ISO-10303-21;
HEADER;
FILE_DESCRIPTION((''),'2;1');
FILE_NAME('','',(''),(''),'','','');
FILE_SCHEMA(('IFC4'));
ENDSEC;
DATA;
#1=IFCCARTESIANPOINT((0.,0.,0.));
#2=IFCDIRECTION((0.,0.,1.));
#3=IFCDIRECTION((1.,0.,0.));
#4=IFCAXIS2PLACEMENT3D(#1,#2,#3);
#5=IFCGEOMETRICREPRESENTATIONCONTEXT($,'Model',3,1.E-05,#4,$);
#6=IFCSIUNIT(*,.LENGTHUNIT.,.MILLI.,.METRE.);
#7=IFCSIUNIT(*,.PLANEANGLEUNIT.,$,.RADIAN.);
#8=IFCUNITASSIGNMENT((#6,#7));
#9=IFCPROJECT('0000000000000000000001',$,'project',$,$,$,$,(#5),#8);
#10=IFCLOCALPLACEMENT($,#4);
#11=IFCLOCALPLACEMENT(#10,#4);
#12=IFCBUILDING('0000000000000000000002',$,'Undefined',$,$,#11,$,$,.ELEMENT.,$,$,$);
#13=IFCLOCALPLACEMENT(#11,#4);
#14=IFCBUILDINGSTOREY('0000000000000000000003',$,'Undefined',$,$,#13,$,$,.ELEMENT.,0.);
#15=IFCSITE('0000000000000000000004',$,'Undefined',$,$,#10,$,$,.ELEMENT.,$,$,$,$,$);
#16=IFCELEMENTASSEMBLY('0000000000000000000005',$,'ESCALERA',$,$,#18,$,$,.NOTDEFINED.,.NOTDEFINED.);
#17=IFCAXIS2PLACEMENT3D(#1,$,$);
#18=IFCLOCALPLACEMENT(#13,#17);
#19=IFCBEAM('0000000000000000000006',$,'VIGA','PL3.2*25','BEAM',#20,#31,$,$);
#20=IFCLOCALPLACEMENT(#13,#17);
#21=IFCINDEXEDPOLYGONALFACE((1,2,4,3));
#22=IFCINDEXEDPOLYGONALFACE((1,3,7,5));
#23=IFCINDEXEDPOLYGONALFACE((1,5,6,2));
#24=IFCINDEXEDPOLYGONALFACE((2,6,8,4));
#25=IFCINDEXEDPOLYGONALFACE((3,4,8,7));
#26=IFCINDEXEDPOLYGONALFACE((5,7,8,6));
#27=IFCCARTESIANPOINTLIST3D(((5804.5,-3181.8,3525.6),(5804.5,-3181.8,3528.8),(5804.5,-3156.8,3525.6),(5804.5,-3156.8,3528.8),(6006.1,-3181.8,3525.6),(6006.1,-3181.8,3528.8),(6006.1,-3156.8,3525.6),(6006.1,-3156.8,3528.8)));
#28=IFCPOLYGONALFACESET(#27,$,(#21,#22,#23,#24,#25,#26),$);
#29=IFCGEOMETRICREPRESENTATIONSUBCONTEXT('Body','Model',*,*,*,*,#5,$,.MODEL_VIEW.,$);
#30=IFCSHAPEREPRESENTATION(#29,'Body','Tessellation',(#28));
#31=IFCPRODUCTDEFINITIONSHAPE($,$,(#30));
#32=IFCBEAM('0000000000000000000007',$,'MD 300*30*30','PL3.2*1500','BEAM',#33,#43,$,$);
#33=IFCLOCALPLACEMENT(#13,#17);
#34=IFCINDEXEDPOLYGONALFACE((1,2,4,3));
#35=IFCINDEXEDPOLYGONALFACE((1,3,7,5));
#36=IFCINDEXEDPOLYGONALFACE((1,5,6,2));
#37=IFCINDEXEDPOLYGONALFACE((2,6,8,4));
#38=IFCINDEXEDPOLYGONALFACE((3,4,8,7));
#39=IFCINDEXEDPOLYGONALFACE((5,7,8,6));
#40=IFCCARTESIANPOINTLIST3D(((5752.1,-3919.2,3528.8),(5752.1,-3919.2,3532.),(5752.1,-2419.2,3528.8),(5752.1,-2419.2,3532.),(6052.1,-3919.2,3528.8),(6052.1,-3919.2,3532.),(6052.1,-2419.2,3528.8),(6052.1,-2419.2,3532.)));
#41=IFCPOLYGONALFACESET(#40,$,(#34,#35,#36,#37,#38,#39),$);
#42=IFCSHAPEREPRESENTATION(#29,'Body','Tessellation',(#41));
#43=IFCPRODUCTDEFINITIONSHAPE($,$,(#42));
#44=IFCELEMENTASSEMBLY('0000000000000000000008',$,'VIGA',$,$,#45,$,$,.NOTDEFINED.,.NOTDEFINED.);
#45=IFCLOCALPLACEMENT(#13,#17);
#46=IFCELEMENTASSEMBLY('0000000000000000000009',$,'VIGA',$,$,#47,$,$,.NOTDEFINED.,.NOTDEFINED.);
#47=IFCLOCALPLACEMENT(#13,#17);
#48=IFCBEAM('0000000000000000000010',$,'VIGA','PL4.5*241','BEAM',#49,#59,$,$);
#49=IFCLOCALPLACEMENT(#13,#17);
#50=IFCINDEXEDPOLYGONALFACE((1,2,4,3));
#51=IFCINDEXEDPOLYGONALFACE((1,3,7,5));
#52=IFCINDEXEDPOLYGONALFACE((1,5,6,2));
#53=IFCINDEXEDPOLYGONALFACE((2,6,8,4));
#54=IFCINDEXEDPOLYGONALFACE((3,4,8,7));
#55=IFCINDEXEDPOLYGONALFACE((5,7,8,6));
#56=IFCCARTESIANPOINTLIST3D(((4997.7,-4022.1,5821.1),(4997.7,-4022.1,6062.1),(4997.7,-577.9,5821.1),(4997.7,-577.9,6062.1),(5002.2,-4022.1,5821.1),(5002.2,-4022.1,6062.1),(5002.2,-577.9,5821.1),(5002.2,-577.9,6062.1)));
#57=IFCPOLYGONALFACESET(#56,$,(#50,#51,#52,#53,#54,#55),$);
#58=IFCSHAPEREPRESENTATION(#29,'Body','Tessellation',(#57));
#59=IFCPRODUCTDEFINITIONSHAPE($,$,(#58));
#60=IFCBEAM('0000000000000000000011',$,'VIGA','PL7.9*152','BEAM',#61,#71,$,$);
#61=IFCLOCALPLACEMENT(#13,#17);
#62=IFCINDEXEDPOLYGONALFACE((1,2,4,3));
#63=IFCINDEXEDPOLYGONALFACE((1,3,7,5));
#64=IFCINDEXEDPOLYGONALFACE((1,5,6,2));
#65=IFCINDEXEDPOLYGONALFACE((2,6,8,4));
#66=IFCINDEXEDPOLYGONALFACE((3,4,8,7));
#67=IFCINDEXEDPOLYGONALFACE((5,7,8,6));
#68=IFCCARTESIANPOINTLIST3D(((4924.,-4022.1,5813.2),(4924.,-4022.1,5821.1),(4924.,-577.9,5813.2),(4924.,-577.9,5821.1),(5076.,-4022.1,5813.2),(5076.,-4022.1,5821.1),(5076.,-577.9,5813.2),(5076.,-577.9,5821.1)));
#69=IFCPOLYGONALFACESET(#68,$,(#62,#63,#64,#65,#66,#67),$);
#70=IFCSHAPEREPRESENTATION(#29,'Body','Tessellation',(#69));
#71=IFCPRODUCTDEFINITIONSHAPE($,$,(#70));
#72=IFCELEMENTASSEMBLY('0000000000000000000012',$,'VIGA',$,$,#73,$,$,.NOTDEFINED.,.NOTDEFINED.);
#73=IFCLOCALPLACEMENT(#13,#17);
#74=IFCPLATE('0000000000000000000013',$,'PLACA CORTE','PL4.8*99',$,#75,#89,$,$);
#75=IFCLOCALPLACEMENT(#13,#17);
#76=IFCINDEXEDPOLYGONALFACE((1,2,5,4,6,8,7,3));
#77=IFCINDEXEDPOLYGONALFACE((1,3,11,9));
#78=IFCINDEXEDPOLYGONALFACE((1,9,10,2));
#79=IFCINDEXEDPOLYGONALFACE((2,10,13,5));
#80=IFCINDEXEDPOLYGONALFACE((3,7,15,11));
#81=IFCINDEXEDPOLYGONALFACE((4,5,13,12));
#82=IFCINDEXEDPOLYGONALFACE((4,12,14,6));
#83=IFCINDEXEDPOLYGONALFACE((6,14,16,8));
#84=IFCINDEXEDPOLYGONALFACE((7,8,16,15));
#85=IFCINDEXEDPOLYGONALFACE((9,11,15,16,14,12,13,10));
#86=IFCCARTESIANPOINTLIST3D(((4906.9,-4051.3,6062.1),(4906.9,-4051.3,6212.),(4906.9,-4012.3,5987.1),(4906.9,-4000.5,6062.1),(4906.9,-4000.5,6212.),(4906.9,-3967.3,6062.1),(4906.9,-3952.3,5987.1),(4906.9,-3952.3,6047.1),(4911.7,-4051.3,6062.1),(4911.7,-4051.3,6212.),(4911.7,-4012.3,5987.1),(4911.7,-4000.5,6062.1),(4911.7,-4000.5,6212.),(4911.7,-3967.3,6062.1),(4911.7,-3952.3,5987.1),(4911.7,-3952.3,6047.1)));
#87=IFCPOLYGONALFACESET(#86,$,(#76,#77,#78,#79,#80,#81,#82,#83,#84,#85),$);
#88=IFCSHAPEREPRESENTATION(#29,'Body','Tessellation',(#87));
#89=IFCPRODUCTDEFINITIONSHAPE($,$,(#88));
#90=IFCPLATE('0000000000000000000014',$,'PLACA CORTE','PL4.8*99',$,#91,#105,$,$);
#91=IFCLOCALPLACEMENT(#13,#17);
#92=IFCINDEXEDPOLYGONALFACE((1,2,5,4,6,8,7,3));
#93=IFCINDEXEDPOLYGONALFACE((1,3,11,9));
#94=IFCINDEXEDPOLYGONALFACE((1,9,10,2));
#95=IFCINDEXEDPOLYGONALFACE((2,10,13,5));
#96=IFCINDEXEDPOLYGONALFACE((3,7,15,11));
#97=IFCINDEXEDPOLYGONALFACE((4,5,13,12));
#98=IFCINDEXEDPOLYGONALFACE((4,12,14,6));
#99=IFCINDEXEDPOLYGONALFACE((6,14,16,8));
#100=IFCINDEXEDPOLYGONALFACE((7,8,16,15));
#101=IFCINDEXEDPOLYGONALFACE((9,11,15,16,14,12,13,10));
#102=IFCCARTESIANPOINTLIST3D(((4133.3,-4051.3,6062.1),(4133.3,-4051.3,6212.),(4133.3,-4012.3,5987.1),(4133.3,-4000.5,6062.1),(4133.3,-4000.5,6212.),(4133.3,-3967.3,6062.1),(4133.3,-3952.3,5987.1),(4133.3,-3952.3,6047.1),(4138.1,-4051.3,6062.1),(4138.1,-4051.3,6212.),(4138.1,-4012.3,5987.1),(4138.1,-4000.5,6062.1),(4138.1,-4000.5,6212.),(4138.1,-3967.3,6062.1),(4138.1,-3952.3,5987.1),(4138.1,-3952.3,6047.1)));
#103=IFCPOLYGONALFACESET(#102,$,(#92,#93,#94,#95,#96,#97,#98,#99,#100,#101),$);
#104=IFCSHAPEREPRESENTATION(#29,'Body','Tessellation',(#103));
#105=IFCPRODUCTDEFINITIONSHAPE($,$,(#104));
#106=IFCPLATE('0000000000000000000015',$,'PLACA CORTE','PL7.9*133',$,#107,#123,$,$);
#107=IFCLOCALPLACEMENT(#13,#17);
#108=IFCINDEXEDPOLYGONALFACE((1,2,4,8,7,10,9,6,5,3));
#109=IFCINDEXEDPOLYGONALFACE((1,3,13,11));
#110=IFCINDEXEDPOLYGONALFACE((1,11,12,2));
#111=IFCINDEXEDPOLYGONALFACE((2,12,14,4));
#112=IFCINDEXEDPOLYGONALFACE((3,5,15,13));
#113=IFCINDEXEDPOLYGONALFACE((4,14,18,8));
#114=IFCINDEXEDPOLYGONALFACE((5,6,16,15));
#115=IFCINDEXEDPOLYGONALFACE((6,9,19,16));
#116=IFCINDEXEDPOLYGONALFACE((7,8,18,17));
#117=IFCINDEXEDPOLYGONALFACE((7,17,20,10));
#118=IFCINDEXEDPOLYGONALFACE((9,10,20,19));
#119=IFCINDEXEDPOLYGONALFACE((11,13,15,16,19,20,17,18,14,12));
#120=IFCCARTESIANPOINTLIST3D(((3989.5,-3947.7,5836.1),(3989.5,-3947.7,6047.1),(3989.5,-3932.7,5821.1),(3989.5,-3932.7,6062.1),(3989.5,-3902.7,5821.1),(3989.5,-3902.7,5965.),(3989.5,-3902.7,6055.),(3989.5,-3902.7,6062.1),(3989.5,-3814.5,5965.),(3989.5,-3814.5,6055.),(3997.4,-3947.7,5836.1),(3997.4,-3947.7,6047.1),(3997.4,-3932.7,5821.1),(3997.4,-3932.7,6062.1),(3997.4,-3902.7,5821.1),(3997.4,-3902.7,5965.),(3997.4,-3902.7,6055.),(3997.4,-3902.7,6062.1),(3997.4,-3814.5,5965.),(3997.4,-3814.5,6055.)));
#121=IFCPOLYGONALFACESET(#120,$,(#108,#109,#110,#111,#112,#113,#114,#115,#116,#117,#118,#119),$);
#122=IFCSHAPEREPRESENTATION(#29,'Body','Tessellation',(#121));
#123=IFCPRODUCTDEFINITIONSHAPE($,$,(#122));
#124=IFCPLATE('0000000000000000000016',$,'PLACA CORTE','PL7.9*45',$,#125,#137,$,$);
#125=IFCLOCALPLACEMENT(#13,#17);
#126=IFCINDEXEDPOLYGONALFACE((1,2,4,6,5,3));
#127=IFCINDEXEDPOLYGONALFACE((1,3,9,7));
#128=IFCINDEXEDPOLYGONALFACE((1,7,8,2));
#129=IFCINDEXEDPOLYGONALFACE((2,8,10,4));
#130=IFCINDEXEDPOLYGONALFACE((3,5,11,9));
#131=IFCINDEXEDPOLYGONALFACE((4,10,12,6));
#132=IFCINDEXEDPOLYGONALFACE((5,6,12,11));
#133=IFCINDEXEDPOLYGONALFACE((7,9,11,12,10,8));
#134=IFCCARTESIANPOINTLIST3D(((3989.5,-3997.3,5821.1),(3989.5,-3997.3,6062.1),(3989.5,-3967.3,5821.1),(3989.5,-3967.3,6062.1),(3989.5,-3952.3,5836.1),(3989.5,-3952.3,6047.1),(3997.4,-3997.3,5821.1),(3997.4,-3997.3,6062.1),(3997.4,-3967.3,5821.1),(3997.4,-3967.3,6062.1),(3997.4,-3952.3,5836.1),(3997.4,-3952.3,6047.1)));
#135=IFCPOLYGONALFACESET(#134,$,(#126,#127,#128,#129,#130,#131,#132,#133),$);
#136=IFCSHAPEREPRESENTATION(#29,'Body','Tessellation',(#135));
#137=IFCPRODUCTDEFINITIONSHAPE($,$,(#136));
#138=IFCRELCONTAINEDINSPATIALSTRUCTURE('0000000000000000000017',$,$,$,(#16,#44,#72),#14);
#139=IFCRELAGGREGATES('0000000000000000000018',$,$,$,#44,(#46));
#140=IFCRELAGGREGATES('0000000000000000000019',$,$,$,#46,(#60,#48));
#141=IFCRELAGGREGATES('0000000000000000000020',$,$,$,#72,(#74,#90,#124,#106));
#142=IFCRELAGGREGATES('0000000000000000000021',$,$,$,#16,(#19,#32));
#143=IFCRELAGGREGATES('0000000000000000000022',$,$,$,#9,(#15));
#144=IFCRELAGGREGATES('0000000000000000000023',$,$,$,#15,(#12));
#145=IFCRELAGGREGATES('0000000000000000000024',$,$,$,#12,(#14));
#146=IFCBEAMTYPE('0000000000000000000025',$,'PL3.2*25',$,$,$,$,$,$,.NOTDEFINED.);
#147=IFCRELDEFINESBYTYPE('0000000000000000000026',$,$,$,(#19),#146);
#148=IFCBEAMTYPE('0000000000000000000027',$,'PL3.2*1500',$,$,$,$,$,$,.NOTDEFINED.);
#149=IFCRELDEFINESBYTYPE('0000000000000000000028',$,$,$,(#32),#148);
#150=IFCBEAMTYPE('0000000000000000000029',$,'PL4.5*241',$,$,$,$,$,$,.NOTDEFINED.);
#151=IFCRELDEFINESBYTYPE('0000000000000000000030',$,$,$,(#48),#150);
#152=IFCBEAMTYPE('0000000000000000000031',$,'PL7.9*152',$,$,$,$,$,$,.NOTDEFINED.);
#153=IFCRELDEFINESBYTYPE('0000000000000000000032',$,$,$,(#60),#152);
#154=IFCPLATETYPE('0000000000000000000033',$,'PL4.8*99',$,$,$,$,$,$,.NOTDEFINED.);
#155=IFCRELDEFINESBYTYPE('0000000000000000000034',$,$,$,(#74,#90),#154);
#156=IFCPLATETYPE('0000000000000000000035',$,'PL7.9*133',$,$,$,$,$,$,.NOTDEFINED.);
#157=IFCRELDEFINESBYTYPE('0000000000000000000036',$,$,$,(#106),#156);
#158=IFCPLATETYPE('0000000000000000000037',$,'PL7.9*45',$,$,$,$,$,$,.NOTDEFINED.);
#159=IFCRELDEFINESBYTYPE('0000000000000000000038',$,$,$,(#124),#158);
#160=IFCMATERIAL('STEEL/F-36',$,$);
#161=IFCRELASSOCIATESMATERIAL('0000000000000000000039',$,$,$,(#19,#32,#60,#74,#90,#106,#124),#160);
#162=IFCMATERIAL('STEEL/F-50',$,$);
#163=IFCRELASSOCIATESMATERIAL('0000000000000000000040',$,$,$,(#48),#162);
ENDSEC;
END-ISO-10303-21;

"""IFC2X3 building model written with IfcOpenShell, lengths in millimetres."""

from ifc_helpers import new_model, si_unit, frame, origin_with_axes, origin_2d_with_axis, place, context, subcontext, project, spatial, polyline, rectangle, outline, extrude, material, type_object, element, aggregate, save


model = new_model("IFC2X3")

# Units and contexts
model_context = context("Model", 3, precision=1e-05, world=origin_with_axes())
body_context = subcontext(model_context, "Body", "Model", "MODEL_VIEW")
ifc_project = project(units=[si_unit("LENGTHUNIT", "METRE", prefix="MILLI"), si_unit("PLANEANGLEUNIT", "RADIAN")], contexts=[model_context])

# Site, building, storey
site_placement = place(None, origin_with_axes())
site = spatial("IfcSite", under=ifc_project, at=site_placement, Name="Undefined", CompositionType="ELEMENT")
building_placement = place(site_placement, origin_with_axes())
building = spatial("IfcBuilding", under=site, at=building_placement, Name="Undefined", CompositionType="ELEMENT")
storey_placement = place(building_placement, origin_with_axes())
storey = spatial("IfcBuildingStorey", under=building, at=storey_placement, Name="Undefined", CompositionType="ELEMENT", Elevation=0.0)

# Element assembly
assembly_1_placement = place(storey_placement, origin_with_axes())
assembly_1 = element("IfcElementAssembly", 1, at=assembly_1_placement, inside=storey, Name="ESCALERA", AssemblyPlace="NOTDEFINED", PredefinedType="NOTDEFINED")
ifc_material_1 = material(Name="STEEL/F-36")

# Beams
beam_type_1 = type_object("IfcBeamType", Name="PL3.2*25", PredefinedType="NOTDEFINED")
beam_1_placement = place(assembly_1_placement, frame((5804.5, -3169.3, 3527.2), z_axis=(0.0, 1.0, 0.0), x_axis=(1.0, 0.0, 0.000012)))
beam_1 = element("IfcBeam", 2, at=beam_1_placement, type_object=beam_type_1, material=ifc_material_1, Name="VIGA", Description="PL3.2*25", ObjectType="BEAM", context=body_context, shape_type="SweptSolid", body=[
    extrude(rectangle(XDim=3.2, YDim=25.0, at=origin_2d_with_axis()), frame((201.6, 0.0, 0.0), z_axis=(-1.0, 0.0, 0.0), x_axis=(0.0, -1.0, 0.0)), (0.0, 0.0, 1.0), 201.6),
])
beam_type_2 = type_object("IfcBeamType", Name="PL3.2*1500", PredefinedType="NOTDEFINED")
beam_2_placement = place(assembly_1_placement, frame((5752.1, -3169.2, 3530.4), z_axis=(0.0, -1.0, 0.0), x_axis=(1.0, 0.0, 0.0)))
beam_2 = element("IfcBeam", 3, at=beam_2_placement, type_object=beam_type_2, material=ifc_material_1, Name="MD 300*30*30", Description="PL3.2*1500", ObjectType="BEAM", context=body_context, shape_type="SweptSolid", body=[
    extrude(rectangle(XDim=3.2, YDim=1500.0, at=origin_2d_with_axis()), frame((300.0, 0.0, 0.0), z_axis=(-1.0, 0.0, 0.0), x_axis=(0.0, -1.0, 0.0)), (0.0, 0.0, 1.0), 300.0),
])

# Element assemblies, beams
assembly_2_placement = place(storey_placement, origin_with_axes())
assembly_2 = element("IfcElementAssembly", 4, at=assembly_2_placement, inside=storey, Name="VIGA", AssemblyPlace="NOTDEFINED", PredefinedType="NOTDEFINED")
assembly_3_placement = place(assembly_2_placement, origin_with_axes())
assembly_3 = element("IfcElementAssembly", 5, at=assembly_3_placement, Name="VIGA", AssemblyPlace="NOTDEFINED", PredefinedType="NOTDEFINED")
aggregate(assembly_2, [assembly_3])
ifc_material_2 = material(Name="STEEL/F-50")
beam_type_3 = type_object("IfcBeamType", Name="PL4.5*241", PredefinedType="NOTDEFINED")
beam_3_placement = place(assembly_3_placement, frame((5000.0, -4022.1, 5941.6), z_axis=(0.0, 0.0, 1.0), x_axis=(0.0, 1.0, 0.0)))
beam_3 = element("IfcBeam", 6, at=beam_3_placement, type_object=beam_type_3, material=ifc_material_2, Name="VIGA", Description="PL4.5*241", ObjectType="BEAM", context=body_context, shape_type="SweptSolid", body=[
    extrude(rectangle(XDim=4.5, YDim=241.0, at=origin_2d_with_axis()), frame((3444.2, 0.0, 0.0), z_axis=(-1.0, 0.0, 0.0), x_axis=(0.0, -1.0, 0.0)), (0.0, 0.0, 1.0), 3444.2),
])
beam_type_4 = type_object("IfcBeamType", Name="PL7.9*152", PredefinedType="NOTDEFINED")
beam_4_placement = place(assembly_3_placement, frame((5000.0, -4022.1, 5817.1), z_axis=(-1.0, 0.0, 0.0), x_axis=(0.0, 1.0, 0.0)))
beam_4 = element("IfcBeam", 7, at=beam_4_placement, type_object=beam_type_4, material=ifc_material_1, Name="VIGA", Description="PL7.9*152", ObjectType="BEAM", context=body_context, shape_type="SweptSolid", body=[
    extrude(rectangle(XDim=7.9, YDim=152.0, at=origin_2d_with_axis()), frame((3444.2, 0.0, 0.0), z_axis=(-1.0, 0.0, 0.0), x_axis=(0.0, -1.0, 0.0)), (0.0, 0.0, 1.0), 3444.2),
])
aggregate(assembly_3, [beam_4, beam_3])

# Element assembly, plates
assembly_4_placement = place(storey_placement, origin_with_axes())
assembly_4 = element("IfcElementAssembly", 8, at=assembly_4_placement, inside=storey, Name="VIGA", AssemblyPlace="NOTDEFINED", PredefinedType="NOTDEFINED")
plate_type_1 = type_object("IfcPlateType", Name="PL4.8*99", PredefinedType="NOTDEFINED")
plate_1_placement = place(assembly_4_placement, frame((4909.3, -3952.3, 5987.1), z_axis=(-1.0, 0.0, 0.000012), x_axis=(0.0, -1.0, 0.0)))
plate_1 = element("IfcPlate", 9, at=plate_1_placement, type_object=plate_type_1, material=ifc_material_1, Name="PLACA CORTE", Description="PL4.8*99", context=body_context, shape_type="SweptSolid", body=[
    extrude(outline(polyline([(0.0, 0.0), (60.0, 0.0), (99.1, 75.0), (99.1, 224.9), (48.3, 224.9), (48.2, 75.0), (15.0, 75.0), (0.0, 60.0), (0.0, 0.0)])), frame((0.0, 0.0, -2.4), z_axis=(0.0, 0.0, 1.0), x_axis=(1.0, 0.0, 0.0)), (0.0, 0.0, 1.0), 4.8),
])
plate_2_placement = place(assembly_4_placement, frame((4135.7, -3952.3, 5987.1), z_axis=(-1.0, 0.0, 0.000012), x_axis=(0.0, -1.0, 0.0)))
plate_2 = element("IfcPlate", 10, at=plate_2_placement, type_object=plate_type_1, material=ifc_material_1, Name="PLACA CORTE", Description="PL4.8*99", context=body_context, shape_type="SweptSolid", body=[
    extrude(outline(polyline([(0.0, 0.0), (60.0, 0.0), (99.1, 75.0), (99.1, 224.9), (48.3, 224.9), (48.2, 75.0), (15.0, 75.0), (0.0, 60.0), (0.0, 0.0)])), frame((0.0, 0.0, -2.4), z_axis=(0.0, 0.0, 1.0), x_axis=(1.0, 0.0, 0.0)), (0.0, 0.0, 1.0), 4.8),
])
plate_type_2 = type_object("IfcPlateType", Name="PL7.9*133", PredefinedType="NOTDEFINED")
plate_3_placement = place(assembly_4_placement, frame((3993.5, -3947.7, 5821.1), z_axis=(1.0, 0.0, 0.0), x_axis=(0.0, 1.0, 0.0)))
plate_3 = element("IfcPlate", 11, at=plate_3_placement, type_object=plate_type_2, material=ifc_material_1, Name="PLACA CORTE", Description="PL7.9*133", context=body_context, shape_type="SweptSolid", body=[
    extrude(outline(polyline([(0.0, 15.0), (15.0, 0.0), (45.0, 0.0), (45.0, 143.9), (133.2, 143.9), (133.2, 233.9), (45.0, 233.9), (45.0, 241.0), (15.0, 241.0), (0.0, 226.0), (0.0, 15.0)])), frame((0.0, 0.0, -4.0), z_axis=(0.0, 0.0, 1.0), x_axis=(1.0, 0.0, 0.0)), (0.0, 0.0, 1.0), 7.9),
])
plate_type_3 = type_object("IfcPlateType", Name="PL7.9*45", PredefinedType="NOTDEFINED")
plate_4_placement = place(assembly_4_placement, frame((3993.5, -3952.3, 5821.1), z_axis=(-1.0, 0.0, 0.0), x_axis=(0.0, -1.0, 0.0)))
plate_4 = element("IfcPlate", 12, at=plate_4_placement, type_object=plate_type_3, material=ifc_material_1, Name="PLACA CORTE", Description="PL7.9*45", context=body_context, shape_type="SweptSolid", body=[
    extrude(outline(polyline([(0.0, 15.0), (15.0, 0.0), (45.0, 0.0), (45.0, 241.0), (15.0, 241.0), (0.0, 226.0), (0.0, 15.0)])), frame((0.0, 0.0, -4.0), z_axis=(0.0, 0.0, 1.0), x_axis=(1.0, 0.0, 0.0)), (0.0, 0.0, 1.0), 7.9),
])
aggregate(assembly_4, [plate_1, plate_2, plate_4, plate_3])

aggregate(assembly_1, [beam_1, beam_2])

save(model, "model.ifc")
